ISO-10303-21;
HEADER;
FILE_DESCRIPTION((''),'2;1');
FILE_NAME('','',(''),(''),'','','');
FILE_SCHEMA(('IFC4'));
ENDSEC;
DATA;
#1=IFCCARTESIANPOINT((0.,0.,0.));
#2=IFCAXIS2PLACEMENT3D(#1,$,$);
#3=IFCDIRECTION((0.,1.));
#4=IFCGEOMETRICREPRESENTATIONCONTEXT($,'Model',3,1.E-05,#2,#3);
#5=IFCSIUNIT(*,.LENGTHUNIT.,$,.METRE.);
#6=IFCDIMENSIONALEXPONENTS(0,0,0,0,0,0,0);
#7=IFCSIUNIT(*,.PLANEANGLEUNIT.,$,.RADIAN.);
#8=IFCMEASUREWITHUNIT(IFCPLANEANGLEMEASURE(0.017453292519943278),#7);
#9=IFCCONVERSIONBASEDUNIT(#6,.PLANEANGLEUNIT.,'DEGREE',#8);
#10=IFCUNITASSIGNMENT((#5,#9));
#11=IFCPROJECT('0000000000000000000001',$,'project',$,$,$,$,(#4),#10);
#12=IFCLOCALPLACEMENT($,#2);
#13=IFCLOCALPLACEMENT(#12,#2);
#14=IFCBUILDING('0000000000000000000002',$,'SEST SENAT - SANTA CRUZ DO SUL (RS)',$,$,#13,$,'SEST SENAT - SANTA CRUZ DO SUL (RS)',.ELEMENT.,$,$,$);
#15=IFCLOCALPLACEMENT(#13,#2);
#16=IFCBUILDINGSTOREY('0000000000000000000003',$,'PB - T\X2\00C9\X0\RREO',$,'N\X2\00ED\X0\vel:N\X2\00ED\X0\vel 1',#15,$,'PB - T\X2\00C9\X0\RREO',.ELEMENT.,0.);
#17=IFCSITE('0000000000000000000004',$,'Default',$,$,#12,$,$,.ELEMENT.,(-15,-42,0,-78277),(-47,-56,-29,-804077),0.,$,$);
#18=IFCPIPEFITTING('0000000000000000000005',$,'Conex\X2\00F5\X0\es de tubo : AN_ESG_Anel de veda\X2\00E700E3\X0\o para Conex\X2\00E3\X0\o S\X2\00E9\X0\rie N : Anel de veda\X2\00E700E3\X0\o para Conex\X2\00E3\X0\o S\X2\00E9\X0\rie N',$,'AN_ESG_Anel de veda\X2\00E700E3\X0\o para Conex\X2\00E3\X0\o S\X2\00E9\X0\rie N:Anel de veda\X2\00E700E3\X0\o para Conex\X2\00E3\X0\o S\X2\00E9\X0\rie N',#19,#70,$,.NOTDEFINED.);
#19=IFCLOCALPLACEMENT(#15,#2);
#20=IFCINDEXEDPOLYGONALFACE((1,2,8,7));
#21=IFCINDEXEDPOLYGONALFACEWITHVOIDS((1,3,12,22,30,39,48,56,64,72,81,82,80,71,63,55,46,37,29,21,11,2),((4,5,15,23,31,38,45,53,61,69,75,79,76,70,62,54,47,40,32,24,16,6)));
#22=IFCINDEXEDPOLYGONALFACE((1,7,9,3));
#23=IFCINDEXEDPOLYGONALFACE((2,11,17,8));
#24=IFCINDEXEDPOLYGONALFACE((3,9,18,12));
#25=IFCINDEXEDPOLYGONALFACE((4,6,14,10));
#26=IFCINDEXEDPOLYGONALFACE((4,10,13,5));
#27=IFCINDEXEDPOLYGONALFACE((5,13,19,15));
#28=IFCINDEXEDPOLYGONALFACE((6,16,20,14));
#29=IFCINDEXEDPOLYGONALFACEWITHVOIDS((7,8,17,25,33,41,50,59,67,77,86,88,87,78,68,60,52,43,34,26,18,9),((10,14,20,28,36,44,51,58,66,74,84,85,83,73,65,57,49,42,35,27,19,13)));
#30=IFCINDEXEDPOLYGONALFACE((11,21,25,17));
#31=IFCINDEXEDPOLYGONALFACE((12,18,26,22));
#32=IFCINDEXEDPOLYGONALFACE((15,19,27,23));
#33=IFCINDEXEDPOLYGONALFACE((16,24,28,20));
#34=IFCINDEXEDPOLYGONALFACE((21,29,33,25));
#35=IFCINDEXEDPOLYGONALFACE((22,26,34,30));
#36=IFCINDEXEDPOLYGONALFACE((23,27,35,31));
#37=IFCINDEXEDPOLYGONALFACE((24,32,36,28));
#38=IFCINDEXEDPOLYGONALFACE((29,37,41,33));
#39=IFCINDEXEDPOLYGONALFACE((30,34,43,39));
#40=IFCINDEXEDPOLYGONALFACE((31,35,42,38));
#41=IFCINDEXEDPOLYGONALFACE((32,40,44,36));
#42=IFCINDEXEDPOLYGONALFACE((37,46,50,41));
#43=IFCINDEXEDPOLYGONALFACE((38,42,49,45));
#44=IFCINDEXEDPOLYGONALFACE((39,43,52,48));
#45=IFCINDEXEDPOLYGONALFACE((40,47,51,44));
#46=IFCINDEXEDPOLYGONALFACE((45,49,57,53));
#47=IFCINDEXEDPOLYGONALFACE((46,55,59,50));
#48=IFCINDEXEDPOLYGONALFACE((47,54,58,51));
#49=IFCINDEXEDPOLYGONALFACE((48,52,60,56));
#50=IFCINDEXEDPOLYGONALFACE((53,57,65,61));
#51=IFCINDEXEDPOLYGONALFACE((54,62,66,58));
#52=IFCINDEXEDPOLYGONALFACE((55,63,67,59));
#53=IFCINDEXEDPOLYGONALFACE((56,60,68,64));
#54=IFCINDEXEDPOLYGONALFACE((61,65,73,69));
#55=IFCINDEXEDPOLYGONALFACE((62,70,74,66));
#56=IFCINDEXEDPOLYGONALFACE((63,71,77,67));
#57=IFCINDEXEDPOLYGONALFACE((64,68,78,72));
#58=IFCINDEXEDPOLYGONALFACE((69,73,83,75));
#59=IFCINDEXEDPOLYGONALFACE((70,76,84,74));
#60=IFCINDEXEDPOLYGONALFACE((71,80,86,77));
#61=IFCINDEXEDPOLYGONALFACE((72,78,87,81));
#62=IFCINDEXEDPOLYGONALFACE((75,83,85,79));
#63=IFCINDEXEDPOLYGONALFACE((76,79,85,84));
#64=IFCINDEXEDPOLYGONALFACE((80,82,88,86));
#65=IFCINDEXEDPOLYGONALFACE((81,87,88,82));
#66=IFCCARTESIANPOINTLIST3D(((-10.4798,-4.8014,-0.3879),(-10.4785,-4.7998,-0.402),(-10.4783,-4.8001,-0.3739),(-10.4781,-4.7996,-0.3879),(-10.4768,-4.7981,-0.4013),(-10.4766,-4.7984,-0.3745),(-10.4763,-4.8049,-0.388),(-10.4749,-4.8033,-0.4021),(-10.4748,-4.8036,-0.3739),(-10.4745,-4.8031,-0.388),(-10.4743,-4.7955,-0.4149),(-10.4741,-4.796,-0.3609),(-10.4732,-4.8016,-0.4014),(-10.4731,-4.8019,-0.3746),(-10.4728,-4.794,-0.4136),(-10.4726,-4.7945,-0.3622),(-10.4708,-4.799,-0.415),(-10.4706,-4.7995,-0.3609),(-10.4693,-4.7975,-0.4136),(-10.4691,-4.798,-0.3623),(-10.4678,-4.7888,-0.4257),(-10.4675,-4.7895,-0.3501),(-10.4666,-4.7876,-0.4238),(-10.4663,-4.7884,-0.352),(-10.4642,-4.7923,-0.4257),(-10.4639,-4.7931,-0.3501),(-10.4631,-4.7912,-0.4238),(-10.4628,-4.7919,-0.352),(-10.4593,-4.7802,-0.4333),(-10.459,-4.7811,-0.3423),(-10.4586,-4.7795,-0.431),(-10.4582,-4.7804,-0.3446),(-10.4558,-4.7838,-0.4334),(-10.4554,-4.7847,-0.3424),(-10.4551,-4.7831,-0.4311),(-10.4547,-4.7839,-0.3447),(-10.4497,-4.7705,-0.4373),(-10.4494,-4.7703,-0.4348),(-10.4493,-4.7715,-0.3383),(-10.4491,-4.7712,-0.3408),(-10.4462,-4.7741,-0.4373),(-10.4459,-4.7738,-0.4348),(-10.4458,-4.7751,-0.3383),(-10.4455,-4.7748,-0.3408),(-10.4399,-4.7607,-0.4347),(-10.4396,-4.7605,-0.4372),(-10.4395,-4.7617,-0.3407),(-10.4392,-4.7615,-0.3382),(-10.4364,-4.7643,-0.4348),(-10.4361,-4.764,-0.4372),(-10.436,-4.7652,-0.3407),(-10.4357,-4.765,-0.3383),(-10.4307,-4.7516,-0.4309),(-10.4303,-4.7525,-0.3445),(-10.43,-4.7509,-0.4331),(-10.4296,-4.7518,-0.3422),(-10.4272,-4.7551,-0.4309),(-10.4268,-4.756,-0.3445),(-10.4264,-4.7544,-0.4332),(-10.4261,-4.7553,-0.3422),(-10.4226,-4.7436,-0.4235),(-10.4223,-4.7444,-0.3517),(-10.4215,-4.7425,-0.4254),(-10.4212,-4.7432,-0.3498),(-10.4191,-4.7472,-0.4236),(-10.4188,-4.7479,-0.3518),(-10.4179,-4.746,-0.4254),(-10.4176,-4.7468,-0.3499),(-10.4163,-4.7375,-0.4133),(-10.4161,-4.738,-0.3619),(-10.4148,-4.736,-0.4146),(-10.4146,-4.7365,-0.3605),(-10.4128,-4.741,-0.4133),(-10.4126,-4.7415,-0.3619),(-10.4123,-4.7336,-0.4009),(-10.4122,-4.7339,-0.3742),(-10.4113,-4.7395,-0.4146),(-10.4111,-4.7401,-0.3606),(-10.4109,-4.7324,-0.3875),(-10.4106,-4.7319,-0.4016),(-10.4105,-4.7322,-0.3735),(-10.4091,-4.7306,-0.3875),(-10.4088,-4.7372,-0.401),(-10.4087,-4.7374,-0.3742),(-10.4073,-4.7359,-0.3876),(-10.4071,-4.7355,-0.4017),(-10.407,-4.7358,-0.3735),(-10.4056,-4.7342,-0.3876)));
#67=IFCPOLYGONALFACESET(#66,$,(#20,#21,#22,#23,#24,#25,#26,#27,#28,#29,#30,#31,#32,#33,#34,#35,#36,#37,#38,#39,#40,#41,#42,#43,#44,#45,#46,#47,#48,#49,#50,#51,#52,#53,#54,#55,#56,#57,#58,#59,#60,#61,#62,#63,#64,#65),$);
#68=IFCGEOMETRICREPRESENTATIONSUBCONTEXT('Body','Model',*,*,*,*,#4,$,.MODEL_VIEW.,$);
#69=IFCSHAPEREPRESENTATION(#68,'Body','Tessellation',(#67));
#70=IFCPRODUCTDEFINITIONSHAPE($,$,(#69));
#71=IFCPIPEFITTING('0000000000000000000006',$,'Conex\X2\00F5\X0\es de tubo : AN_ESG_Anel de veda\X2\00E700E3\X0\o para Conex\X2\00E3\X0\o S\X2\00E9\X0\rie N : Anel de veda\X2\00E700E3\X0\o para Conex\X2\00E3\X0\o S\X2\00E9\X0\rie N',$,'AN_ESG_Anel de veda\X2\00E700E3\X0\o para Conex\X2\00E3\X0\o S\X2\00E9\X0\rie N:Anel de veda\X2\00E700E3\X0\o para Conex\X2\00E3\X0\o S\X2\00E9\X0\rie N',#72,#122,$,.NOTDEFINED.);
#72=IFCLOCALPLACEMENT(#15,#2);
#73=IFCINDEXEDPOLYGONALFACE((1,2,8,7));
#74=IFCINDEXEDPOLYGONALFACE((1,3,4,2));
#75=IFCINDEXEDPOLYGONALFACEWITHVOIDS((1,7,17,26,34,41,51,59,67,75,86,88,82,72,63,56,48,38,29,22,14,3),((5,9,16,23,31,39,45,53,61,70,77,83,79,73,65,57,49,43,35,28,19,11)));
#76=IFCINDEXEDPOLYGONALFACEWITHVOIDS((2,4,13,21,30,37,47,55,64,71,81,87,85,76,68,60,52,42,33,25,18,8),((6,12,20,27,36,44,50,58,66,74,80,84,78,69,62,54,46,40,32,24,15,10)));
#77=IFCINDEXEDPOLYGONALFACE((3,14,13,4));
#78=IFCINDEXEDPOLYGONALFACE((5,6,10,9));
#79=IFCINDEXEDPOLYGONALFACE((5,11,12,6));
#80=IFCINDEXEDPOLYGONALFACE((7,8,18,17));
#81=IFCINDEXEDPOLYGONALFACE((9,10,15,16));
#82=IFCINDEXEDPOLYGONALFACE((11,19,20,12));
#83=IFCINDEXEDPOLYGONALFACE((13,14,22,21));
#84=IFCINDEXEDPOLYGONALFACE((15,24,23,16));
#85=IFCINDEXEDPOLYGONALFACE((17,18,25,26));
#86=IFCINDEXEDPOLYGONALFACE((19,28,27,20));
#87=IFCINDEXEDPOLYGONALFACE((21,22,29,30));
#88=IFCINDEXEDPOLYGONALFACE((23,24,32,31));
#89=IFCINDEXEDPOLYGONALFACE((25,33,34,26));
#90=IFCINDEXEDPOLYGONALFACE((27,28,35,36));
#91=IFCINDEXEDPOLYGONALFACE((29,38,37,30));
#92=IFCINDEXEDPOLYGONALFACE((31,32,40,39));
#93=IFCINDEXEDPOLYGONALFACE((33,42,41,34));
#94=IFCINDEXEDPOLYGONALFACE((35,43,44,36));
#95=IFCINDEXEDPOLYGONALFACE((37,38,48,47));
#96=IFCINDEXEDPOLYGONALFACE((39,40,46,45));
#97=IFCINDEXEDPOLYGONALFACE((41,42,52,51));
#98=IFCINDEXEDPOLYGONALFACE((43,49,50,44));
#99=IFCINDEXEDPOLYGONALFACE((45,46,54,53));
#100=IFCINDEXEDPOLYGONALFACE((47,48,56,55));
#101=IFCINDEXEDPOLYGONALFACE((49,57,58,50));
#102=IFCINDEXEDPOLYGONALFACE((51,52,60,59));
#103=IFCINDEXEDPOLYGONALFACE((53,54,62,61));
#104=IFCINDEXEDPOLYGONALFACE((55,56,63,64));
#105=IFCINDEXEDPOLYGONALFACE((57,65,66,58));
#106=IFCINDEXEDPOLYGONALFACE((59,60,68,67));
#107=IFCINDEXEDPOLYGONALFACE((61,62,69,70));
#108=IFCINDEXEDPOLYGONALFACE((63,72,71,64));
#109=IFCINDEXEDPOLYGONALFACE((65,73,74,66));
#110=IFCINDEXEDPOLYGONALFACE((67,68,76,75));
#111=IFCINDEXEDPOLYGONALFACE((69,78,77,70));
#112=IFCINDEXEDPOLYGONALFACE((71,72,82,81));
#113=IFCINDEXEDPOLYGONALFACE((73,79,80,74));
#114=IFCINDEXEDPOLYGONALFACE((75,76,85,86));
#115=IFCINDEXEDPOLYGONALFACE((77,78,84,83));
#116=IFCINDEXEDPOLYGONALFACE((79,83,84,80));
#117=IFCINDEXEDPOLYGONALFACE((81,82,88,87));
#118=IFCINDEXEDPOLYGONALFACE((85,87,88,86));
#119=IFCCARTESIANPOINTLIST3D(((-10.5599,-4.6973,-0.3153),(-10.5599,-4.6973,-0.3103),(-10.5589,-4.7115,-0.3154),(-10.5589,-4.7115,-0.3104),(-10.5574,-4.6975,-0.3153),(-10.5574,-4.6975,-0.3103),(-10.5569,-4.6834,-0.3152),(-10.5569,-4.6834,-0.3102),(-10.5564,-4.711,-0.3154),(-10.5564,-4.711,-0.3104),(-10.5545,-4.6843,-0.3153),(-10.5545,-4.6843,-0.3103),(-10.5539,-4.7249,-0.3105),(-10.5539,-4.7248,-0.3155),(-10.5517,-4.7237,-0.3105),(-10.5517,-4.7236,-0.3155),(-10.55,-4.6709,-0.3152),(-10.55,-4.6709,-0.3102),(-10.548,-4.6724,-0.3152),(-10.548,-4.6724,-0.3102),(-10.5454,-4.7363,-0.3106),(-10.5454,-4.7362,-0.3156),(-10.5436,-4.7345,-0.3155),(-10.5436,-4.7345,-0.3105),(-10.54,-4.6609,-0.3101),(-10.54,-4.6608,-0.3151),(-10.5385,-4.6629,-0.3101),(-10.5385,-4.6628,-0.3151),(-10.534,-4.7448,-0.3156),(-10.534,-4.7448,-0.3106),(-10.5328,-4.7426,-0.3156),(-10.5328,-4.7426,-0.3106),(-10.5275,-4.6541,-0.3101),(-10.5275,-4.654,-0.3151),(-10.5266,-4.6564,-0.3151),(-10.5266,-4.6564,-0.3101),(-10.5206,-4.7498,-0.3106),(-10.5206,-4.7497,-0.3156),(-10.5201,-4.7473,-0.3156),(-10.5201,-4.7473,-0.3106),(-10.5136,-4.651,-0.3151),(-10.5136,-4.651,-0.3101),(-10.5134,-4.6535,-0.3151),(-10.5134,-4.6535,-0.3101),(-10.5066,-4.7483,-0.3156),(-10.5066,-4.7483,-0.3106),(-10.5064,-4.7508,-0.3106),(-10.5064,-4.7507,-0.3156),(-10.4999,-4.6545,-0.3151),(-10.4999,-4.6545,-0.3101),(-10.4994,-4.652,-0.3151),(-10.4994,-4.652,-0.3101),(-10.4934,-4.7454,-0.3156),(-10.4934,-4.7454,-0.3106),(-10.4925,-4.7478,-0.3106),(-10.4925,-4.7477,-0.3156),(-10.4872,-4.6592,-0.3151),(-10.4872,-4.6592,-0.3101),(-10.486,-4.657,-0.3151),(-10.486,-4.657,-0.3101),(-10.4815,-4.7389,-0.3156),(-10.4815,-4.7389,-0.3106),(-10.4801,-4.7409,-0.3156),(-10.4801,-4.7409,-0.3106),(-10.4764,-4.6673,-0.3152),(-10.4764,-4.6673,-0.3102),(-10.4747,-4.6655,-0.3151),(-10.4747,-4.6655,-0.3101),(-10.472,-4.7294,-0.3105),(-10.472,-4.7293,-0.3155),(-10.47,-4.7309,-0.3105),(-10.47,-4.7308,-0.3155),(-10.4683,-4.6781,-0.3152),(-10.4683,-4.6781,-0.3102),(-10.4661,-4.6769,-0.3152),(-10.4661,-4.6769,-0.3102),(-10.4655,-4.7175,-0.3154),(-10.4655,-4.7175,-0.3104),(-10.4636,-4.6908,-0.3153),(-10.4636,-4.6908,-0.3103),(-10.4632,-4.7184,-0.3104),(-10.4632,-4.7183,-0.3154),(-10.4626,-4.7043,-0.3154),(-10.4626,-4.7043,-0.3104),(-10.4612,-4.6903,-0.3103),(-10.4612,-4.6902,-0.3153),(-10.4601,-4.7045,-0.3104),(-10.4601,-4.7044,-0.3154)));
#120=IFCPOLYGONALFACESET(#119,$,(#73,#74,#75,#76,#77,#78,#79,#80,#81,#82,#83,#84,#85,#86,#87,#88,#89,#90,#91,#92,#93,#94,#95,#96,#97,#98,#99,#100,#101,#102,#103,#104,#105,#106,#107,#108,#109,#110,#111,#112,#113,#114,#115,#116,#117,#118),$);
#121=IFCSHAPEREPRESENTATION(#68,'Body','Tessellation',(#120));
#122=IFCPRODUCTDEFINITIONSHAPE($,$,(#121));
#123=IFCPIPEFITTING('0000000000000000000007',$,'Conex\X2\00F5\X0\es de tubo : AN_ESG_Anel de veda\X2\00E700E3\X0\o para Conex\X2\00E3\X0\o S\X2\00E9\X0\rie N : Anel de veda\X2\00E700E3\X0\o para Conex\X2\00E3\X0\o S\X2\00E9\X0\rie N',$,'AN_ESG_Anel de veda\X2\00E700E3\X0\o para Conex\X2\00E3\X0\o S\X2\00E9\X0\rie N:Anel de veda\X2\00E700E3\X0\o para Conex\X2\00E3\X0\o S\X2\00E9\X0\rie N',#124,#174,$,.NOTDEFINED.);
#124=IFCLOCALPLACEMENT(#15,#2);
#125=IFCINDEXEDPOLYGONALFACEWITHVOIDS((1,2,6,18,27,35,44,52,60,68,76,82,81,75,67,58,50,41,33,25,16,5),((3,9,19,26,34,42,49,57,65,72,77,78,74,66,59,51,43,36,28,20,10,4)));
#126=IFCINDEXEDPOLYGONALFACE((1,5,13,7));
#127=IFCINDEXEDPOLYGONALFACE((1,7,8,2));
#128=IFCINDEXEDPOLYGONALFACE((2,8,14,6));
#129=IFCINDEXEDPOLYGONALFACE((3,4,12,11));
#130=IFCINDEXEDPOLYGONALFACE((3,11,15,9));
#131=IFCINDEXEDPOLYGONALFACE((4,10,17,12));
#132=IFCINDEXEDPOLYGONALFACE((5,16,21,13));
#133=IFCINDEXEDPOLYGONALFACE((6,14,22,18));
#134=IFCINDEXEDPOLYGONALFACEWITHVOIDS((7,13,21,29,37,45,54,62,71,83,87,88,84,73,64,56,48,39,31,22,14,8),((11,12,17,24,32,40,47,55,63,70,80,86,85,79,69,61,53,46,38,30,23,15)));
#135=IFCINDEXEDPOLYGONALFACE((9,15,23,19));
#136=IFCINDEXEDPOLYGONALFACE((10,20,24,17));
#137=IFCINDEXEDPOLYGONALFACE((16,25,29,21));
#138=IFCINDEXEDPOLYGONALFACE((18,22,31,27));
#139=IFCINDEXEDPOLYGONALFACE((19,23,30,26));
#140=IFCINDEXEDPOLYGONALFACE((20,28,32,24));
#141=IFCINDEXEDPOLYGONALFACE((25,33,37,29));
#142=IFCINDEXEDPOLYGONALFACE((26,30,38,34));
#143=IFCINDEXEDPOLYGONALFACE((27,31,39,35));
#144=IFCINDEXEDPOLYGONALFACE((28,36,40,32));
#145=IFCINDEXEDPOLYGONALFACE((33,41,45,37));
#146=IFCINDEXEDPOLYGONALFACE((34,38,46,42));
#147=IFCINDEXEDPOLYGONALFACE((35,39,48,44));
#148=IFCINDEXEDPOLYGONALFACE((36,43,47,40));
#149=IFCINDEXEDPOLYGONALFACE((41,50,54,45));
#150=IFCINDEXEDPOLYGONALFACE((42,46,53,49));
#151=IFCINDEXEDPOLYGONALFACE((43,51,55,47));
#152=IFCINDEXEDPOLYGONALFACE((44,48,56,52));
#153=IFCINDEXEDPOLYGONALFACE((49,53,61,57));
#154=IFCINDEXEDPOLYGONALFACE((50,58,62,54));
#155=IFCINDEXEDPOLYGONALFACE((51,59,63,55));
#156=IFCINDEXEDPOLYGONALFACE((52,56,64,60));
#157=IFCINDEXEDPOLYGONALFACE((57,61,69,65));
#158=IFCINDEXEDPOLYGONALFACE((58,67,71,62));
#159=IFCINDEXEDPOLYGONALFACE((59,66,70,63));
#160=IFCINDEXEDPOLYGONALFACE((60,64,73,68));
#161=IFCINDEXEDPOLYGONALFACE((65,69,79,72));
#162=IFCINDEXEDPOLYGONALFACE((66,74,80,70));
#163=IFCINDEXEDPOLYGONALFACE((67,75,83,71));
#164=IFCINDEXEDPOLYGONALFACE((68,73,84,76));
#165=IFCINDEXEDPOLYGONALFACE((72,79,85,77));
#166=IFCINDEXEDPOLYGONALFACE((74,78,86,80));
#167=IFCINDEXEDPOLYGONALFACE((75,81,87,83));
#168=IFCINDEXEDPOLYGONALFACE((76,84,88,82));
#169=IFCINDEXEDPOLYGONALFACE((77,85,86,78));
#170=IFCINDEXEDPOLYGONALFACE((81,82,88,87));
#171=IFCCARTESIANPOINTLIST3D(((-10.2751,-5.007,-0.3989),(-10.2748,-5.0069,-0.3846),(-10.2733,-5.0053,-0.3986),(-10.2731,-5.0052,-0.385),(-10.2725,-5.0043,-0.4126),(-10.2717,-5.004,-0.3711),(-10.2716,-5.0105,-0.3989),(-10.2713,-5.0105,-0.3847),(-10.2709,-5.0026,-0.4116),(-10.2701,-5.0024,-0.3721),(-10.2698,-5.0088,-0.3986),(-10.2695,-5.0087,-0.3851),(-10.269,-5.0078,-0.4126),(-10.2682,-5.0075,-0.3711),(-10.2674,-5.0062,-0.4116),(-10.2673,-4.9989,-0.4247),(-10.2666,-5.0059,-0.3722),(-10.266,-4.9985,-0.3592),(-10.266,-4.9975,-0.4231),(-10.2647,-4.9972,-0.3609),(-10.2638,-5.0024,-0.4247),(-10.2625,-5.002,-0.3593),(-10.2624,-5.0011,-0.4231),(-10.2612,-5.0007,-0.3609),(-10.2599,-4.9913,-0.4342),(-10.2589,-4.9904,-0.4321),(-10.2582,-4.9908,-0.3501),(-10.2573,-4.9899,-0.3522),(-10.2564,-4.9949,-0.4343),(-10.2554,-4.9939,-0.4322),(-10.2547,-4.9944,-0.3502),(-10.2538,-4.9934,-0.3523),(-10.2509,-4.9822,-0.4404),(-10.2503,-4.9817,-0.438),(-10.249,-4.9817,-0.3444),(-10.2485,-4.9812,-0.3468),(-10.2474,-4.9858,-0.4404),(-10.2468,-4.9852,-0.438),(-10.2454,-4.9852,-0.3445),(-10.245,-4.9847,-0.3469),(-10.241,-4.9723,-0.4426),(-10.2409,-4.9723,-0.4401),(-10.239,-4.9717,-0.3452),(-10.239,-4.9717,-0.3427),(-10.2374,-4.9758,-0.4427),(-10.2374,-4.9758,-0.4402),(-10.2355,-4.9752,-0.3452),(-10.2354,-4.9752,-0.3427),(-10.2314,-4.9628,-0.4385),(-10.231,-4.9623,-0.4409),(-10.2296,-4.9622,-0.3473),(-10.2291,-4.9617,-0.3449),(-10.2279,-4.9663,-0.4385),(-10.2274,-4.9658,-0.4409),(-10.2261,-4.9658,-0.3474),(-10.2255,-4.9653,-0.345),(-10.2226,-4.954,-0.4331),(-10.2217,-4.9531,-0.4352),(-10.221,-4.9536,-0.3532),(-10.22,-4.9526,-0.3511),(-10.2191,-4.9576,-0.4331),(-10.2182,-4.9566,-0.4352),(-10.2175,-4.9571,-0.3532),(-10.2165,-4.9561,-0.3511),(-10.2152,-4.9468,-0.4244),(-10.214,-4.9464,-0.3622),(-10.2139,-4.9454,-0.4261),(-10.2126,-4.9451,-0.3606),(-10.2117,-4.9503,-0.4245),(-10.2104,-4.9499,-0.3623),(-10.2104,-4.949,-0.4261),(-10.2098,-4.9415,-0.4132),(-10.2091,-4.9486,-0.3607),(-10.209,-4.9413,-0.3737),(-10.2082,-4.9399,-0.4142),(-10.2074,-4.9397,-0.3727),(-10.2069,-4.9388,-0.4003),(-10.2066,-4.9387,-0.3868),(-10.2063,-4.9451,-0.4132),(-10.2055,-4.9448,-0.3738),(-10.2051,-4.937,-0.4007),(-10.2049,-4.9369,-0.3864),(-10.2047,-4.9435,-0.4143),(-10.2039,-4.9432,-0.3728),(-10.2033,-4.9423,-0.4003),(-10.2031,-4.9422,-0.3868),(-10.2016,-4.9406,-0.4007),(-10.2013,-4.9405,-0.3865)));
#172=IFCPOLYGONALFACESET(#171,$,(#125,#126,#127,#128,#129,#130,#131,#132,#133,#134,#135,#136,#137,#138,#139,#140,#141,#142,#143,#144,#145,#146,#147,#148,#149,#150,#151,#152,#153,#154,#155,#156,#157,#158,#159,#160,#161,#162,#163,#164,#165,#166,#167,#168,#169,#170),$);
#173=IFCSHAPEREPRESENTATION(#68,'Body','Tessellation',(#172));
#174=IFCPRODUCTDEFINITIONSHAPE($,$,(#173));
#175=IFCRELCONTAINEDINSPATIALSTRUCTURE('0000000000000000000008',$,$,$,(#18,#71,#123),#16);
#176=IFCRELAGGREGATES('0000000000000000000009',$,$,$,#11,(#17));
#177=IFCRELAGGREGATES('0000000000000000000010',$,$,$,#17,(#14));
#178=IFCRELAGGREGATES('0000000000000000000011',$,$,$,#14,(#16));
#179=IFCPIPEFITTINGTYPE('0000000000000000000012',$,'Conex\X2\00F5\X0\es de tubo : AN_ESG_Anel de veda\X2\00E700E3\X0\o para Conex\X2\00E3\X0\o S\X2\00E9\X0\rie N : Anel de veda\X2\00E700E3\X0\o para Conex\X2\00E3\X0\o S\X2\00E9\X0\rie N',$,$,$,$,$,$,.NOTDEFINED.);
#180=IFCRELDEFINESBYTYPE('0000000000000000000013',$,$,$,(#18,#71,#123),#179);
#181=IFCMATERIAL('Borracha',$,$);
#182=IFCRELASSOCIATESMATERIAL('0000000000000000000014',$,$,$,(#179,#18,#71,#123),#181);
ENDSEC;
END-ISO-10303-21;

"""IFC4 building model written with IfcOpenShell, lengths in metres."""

from ifc_helpers import new_model, entity, si_unit, converted_unit, direction, frame, origin, place, context, subcontext, project, spatial, arc, indexed_curve, outline, extrude, source, transform, mapped, material, type_object, type_shapes, element, save


model = new_model("IFC4")

# Units and contexts
model_context = context("Model", 3, precision=1e-05, world=origin(), true_north=direction((0.0, 1.0)))
body_context = subcontext(model_context, "Body", "Model", "MODEL_VIEW")
ifc_project = project(units=[si_unit("LENGTHUNIT", "METRE"), converted_unit("PLANEANGLEUNIT", "DEGREE", entity("IfcPlaneAngleMeasure", 0.017453292519943278), si_unit("PLANEANGLEUNIT", "RADIAN"), dimensions=[0, 0, 0, 0, 0, 0, 0])], contexts=[model_context])

# Site, building, storey
site_placement = place(None, origin())
site = spatial("IfcSite", under=ifc_project, at=site_placement, Name="Default", CompositionType="ELEMENT", RefLatitude=(-15, -42, 0, -78277), RefLongitude=(-47, -56, -29, -804077), RefElevation=0.0)
building_placement = place(site_placement, origin())
building = spatial("IfcBuilding", under=site, at=building_placement, Name="SEST SENAT - SANTA CRUZ DO SUL (RS)", LongName="SEST SENAT - SANTA CRUZ DO SUL (RS)", CompositionType="ELEMENT")
storey_placement = place(building_placement, origin())
storey = spatial("IfcBuildingStorey", under=building, at=storey_placement, Name="PB - TÉRREO", ObjectType="Nível:Nível 1", LongName="PB - TÉRREO", CompositionType="ELEMENT", Elevation=0.0)

# Pipe fittings
ifc_material_1 = material(Name="Borracha")
pipe_fitting_type_1 = type_object("IfcPipeFittingType", Name="Conexões de tubo : AN_ESG_Anel de vedação para Conexão Série N : Anel de vedação para Conexão Série N", PredefinedType="NOTDEFINED", material=ifc_material_1)
shared_shape_1 = source(origin(), body_context, "Body", "SweptSolid", [
    extrude(outline(indexed_curve([(-0.05, 0.0), (0.0, -0.05), (0.05, 0.0), (0.0, 0.05)], segments=[arc(1, 2, 3), arc(3, 4, 1)], self_intersect=False), holes=[indexed_curve([(-0.0475, 0.0), (0.0, 0.0475), (0.0475, 0.0), (0.0, -0.0475)], segments=[arc(1, 2, 3), arc(3, 4, 1)], self_intersect=False)]), frame((0.0, 0.0, -0.005)), (0.0, 0.0, 1.0), 0.005),
])
type_shapes(pipe_fitting_type_1, [shared_shape_1])
for number, where, z_axis, x_axis, name in (
    (1, (-10.4409, -4.7695, -0.3878), (0.707071, -0.707071, -0.01), (0.70713, 0.707071, 0.004142), "Conexões de tubo : AN_ESG_Anel de vedação para Conexão Série N : Anel de vedação para Conexão Série N"),
    (2, (-10.51, -4.7009, -0.3153), (0.0, 0.005858, -0.999983), (0.70713, 0.707071, 0.004142), "Conexões de tubo : AN_ESG_Anel de vedação para Conexão Série N : Anel de vedação para Conexão Série N"),
    (3, (-10.2364, -4.9755, -0.3927), (0.707071, -0.707071, -0.01), (-0.019996, -0.005857, -0.999783), "Conexões de tubo : AN_ESG_Anel de vedação para Conexão Série N : Anel de vedação para Conexão Série N"),
):
    element("IfcPipeFitting", number, at=place(storey_placement, frame(where, z_axis=z_axis, x_axis=x_axis)), inside=storey, type_object=pipe_fitting_type_1, material=ifc_material_1, Name=name, ObjectType="AN_ESG_Anel de vedação para Conexão Série N:Anel de vedação para Conexão Série N", PredefinedType="NOTDEFINED", context=body_context, shape_type="MappedRepresentation", body=[
        mapped(shared_shape_1, transform((0.0, 0.0, 0.0), scale=1.0)),
    ])

save(model, "model.ifc")
